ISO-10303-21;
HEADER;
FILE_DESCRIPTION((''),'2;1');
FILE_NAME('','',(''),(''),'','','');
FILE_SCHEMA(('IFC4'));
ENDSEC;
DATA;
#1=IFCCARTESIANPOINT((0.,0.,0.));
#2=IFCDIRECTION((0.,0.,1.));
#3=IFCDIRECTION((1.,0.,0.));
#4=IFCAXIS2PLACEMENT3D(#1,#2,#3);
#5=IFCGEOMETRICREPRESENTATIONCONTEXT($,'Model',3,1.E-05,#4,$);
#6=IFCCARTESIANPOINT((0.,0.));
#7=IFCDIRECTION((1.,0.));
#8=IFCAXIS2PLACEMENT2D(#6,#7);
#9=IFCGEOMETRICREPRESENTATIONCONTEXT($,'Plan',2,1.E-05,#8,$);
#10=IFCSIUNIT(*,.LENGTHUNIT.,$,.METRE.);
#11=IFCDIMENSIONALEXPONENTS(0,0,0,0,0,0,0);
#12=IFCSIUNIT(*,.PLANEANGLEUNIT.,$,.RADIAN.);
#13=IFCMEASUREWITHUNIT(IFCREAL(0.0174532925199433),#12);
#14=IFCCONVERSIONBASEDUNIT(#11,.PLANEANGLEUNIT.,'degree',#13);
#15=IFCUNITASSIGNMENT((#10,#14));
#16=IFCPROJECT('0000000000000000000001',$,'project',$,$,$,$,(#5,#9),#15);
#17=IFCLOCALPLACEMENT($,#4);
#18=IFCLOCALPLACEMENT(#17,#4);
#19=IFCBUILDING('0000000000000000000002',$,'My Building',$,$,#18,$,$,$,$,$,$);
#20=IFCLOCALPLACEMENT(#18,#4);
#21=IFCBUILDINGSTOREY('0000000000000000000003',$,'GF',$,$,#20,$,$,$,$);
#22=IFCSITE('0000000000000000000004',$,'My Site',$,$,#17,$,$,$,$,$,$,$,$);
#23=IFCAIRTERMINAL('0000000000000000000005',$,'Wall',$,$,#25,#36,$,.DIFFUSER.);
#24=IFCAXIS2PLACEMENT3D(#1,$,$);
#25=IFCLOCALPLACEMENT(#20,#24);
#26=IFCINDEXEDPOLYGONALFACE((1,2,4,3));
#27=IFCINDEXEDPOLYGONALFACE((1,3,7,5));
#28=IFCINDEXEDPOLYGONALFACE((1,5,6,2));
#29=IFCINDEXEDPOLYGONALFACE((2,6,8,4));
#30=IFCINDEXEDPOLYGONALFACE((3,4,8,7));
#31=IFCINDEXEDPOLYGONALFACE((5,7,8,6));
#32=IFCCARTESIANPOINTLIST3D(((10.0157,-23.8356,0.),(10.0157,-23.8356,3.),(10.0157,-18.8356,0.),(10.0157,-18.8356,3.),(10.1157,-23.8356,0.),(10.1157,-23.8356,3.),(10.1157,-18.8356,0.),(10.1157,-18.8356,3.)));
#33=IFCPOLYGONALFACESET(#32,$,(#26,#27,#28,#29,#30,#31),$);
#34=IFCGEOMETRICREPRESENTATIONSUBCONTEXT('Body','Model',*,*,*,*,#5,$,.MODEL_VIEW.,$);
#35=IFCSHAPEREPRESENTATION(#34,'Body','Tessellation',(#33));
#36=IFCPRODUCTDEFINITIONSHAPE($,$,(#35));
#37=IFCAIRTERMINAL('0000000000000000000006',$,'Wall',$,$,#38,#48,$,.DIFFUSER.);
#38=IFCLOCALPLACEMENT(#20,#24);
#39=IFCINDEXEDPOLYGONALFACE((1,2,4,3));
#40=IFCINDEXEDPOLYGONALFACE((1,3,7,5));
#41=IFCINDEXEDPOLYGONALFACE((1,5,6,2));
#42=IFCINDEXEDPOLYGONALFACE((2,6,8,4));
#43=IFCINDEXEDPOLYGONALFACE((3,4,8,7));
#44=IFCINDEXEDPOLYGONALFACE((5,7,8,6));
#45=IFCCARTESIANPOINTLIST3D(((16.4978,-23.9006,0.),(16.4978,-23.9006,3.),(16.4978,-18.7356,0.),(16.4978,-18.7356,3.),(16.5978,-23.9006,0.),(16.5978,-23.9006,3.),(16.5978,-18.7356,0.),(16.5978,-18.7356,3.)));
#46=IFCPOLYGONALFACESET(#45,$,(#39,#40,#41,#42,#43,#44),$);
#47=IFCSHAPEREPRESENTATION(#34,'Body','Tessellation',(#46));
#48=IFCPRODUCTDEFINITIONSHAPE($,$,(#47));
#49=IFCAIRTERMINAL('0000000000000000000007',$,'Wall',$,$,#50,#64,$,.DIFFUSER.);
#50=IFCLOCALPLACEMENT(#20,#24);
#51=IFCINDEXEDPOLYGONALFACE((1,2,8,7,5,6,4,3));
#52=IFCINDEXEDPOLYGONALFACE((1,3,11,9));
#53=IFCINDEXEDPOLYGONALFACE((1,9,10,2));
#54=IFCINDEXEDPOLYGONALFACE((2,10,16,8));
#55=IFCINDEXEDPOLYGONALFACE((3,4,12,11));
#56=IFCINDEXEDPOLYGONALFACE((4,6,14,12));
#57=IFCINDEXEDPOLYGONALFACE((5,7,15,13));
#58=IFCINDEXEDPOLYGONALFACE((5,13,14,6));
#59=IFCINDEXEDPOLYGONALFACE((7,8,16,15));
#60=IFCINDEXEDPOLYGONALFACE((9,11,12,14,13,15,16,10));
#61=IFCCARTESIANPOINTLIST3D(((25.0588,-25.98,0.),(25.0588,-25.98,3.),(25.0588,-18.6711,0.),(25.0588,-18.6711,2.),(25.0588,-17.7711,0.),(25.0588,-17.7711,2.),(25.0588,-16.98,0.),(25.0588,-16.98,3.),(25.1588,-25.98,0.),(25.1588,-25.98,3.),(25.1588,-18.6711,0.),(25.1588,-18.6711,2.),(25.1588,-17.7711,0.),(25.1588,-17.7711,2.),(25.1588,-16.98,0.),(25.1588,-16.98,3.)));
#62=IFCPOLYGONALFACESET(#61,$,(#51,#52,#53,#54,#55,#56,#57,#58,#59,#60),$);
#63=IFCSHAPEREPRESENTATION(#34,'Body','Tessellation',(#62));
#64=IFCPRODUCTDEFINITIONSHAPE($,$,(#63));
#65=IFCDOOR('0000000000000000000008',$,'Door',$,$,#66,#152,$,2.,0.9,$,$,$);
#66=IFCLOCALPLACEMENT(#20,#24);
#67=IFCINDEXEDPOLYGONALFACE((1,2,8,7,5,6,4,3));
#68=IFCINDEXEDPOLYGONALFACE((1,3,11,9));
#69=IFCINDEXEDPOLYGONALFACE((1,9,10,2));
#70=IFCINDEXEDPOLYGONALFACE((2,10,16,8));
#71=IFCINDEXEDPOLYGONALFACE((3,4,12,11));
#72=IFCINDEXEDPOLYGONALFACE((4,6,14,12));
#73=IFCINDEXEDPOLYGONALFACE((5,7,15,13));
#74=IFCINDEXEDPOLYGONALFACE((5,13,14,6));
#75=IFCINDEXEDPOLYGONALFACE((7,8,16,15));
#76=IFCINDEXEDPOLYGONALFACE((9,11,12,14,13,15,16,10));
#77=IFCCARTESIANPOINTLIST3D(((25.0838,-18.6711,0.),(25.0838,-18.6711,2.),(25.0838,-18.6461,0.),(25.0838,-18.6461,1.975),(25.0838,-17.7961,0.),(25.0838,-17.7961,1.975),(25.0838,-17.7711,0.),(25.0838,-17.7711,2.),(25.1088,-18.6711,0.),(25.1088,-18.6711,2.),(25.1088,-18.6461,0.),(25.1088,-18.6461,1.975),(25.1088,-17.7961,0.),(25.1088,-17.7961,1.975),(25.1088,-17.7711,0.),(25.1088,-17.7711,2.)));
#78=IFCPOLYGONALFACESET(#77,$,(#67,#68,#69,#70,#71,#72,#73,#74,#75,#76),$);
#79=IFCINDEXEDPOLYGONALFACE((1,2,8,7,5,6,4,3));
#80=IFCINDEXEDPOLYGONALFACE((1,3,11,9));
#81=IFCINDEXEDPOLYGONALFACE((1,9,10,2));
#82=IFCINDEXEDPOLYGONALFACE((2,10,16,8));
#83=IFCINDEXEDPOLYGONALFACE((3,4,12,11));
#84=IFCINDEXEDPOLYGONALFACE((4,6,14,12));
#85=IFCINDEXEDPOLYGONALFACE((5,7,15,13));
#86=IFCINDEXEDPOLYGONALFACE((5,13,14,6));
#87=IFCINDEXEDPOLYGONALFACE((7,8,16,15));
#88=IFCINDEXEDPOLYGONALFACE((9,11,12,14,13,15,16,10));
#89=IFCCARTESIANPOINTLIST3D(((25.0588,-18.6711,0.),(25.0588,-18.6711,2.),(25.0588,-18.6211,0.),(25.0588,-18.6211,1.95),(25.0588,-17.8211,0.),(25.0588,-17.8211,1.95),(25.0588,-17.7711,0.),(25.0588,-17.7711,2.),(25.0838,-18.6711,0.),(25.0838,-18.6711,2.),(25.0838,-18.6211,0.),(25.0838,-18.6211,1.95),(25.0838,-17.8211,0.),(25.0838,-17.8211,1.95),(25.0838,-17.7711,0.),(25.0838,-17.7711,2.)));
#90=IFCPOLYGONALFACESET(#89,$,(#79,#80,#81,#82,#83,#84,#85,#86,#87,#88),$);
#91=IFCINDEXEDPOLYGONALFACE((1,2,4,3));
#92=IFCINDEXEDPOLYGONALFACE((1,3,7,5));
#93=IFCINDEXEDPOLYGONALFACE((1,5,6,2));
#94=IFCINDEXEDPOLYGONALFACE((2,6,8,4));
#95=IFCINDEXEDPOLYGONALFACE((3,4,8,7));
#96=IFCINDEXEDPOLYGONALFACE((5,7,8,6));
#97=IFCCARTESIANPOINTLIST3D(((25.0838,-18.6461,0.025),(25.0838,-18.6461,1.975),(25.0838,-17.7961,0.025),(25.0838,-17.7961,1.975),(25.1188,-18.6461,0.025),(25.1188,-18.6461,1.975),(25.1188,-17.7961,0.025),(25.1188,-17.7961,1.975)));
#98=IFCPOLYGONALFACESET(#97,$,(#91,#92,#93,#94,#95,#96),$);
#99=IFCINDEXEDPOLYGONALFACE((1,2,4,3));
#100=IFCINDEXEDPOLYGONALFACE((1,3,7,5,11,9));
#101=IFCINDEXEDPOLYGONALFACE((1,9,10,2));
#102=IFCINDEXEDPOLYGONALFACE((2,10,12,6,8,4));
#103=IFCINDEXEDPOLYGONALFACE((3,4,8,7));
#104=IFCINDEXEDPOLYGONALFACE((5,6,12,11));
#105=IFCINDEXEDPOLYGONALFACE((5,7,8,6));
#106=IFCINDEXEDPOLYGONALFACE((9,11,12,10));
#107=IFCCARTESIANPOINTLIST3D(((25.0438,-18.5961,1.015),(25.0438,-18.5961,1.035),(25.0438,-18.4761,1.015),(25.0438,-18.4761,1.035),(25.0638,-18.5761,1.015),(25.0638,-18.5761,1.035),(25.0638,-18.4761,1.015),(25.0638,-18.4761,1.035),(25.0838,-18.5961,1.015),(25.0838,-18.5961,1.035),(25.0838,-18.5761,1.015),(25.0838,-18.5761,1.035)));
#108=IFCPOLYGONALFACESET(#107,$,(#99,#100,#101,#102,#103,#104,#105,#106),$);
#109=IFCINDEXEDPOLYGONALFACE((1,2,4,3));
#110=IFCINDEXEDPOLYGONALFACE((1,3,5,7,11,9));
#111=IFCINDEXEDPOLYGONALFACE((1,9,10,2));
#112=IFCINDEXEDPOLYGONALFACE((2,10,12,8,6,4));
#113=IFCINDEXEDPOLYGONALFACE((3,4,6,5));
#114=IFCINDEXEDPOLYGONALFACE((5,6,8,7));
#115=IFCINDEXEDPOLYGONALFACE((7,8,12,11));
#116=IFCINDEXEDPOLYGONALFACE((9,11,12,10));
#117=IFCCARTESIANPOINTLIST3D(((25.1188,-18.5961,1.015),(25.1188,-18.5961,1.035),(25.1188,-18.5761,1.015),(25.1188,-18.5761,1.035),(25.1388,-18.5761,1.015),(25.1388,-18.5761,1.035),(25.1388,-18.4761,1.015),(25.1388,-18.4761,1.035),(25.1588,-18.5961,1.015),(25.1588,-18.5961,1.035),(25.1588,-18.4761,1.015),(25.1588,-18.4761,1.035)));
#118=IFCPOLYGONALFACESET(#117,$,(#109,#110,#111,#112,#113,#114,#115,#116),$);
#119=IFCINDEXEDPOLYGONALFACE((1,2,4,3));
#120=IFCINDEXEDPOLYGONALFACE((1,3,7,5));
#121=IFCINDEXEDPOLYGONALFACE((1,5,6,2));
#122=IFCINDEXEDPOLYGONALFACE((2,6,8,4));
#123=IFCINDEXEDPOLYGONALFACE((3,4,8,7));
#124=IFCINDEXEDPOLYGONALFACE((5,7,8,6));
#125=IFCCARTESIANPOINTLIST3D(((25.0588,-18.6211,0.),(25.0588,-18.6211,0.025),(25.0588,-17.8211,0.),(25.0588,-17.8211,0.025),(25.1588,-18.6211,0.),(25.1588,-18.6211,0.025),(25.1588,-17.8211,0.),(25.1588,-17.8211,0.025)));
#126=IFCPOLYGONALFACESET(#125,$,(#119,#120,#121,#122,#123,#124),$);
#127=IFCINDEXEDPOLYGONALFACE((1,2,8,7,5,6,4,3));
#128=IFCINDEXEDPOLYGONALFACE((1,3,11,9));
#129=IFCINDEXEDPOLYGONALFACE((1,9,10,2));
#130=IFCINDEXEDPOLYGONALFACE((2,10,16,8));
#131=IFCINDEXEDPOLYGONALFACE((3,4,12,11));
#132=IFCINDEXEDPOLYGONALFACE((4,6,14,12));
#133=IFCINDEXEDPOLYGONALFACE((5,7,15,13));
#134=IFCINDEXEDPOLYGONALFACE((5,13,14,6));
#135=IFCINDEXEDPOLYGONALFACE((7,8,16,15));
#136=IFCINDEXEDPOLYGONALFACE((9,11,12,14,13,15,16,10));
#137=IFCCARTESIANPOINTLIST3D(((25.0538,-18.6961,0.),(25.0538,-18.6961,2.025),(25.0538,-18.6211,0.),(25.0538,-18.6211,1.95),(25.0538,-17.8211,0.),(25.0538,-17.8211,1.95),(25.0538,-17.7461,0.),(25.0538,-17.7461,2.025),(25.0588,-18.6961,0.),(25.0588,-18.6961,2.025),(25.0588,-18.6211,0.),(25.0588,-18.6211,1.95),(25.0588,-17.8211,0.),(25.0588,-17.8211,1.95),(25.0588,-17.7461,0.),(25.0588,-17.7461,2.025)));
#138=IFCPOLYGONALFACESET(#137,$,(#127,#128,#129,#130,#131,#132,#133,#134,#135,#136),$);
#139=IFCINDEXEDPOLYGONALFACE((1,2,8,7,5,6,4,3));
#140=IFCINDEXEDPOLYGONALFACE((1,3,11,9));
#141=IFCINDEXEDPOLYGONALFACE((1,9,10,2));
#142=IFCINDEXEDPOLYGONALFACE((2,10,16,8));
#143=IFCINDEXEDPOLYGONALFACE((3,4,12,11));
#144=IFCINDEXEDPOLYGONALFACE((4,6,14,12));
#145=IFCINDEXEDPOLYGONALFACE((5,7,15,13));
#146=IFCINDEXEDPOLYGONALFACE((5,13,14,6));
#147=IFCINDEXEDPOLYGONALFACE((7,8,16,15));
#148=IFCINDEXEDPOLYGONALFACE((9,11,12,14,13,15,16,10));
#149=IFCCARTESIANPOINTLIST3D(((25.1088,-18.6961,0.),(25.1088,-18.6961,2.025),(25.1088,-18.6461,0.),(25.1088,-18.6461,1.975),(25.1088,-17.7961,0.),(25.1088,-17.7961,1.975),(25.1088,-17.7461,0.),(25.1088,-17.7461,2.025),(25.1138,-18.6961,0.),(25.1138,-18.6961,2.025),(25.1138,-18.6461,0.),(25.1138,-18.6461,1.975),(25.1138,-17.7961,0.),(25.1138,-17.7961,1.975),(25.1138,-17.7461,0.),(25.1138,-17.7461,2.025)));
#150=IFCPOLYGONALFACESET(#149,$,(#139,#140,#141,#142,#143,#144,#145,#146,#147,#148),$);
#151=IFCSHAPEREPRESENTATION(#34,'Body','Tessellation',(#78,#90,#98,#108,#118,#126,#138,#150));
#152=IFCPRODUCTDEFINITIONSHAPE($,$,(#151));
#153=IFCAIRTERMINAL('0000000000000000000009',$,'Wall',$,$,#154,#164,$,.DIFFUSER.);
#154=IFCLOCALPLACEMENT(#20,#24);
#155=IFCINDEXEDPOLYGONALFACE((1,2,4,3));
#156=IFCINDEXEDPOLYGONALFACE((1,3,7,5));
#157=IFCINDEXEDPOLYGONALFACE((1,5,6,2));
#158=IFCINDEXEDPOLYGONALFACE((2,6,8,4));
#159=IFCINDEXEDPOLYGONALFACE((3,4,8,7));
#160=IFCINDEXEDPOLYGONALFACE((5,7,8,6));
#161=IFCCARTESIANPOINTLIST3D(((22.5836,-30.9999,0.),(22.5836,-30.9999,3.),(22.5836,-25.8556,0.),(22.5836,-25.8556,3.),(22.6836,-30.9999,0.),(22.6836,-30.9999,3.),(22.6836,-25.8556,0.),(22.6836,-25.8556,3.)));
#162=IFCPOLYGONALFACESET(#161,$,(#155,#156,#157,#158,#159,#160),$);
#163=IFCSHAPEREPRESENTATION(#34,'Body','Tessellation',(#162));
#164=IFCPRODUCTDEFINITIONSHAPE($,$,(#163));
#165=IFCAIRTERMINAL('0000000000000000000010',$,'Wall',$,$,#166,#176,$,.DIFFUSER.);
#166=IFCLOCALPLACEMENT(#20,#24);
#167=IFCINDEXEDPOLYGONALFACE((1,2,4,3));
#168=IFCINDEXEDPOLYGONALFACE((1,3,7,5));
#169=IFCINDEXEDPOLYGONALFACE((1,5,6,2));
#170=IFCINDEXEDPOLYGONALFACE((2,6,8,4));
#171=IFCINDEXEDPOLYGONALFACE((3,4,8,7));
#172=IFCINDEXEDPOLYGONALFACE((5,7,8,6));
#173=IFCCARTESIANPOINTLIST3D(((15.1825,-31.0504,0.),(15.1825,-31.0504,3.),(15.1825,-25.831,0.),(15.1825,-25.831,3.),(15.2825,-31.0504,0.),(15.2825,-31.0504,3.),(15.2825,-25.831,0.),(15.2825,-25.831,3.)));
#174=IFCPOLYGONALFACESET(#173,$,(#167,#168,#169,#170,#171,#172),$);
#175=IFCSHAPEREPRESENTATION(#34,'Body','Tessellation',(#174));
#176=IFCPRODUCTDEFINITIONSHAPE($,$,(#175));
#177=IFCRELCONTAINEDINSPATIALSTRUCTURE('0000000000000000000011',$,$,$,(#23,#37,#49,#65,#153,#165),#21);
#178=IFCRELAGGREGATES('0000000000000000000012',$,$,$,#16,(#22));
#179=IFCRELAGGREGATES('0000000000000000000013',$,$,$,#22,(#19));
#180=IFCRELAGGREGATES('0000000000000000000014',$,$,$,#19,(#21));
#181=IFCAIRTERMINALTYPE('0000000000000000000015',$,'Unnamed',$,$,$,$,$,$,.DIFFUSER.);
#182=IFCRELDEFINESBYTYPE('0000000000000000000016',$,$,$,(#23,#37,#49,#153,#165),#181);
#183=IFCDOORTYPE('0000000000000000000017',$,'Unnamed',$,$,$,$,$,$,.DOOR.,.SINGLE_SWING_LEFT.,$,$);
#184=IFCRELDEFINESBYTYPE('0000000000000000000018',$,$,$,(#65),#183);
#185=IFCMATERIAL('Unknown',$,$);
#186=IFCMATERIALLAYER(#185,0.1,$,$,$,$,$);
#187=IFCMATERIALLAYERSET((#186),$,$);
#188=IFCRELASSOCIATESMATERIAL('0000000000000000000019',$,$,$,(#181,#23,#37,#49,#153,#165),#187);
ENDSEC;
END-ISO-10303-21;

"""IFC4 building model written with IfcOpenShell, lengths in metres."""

from ifc_helpers import new_model, entity, si_unit, converted_unit, frame, origin_with_axes, origin_2d_with_axis, place, context, subcontext, project, spatial, line, indexed_curve, outline, extrude, shape, source, transform, mapped, material, layer, layer_set, layer_usage, type_object, type_shapes, element, fill, save


model = new_model("IFC4")

# Units and contexts
model_context = context("Model", 3, precision=1e-05, world=origin_with_axes())
plan_context = context("Plan", 2, precision=1e-05, world=origin_2d_with_axis())
body_context_1 = subcontext(model_context, "Body", "Model", "MODEL_VIEW")
body_context_2 = subcontext(plan_context, "Body", "Plan", "PLAN_VIEW")
ifc_project = project(units=[si_unit("LENGTHUNIT", "METRE"), converted_unit("PLANEANGLEUNIT", "degree", entity("IfcReal", 0.0174532925199433), si_unit("PLANEANGLEUNIT", "RADIAN"), dimensions=[0, 0, 0, 0, 0, 0, 0])], contexts=[model_context, plan_context])

# Site, building, storey
site_placement = place(None, origin_with_axes())
site = spatial("IfcSite", under=ifc_project, at=site_placement, Name="My Site")
building_placement = place(site_placement, origin_with_axes())
building = spatial("IfcBuilding", under=site, at=building_placement, Name="My Building")
storey_placement = place(building_placement, origin_with_axes())
storey = spatial("IfcBuildingStorey", under=building, at=storey_placement, Name="GF")

# Shared definitions
ifc_material = material(Name="Unknown")
ifc_layer = layer(ifc_material, 0.1)
ifc_layer_set = layer_set([ifc_layer])
air_terminal_type = type_object("IfcAirTerminalType", Name="Unnamed", PredefinedType="DIFFUSER", material=ifc_layer_set)

# Shared definitions
shared_shape_1 = source(origin_with_axes(), body_context_1, "Body", "SweptSolid", [
    extrude(outline(indexed_curve([(0.0, 0.0), (0.9, 0.0), (0.9, 2.0), (0.0, 2.0)], segments=[line(1, 2, 3, 4, 1)])), frame((0.0, -0.6, 0.0), z_axis=(0.0, -1.0, 0.0), x_axis=(1.0, 0.0, 0.0)), (0.0, 0.0, -1.0), 1.2),
])
door_type = type_object("IfcDoorType", Name="Unnamed", OperationType="SINGLE_SWING_LEFT", PredefinedType="DOOR")
shared_shape_2 = source(origin_with_axes(), body_context_1, "Body", "SweptSolid", [
    extrude(outline(indexed_curve([(0.0, 0.0), (0.0, 2.0), (0.9, 2.0), (0.9, 0.0), (0.875, 0.0), (0.875, 1.975), (0.025, 1.975), (0.025, 0.0)], segments=[line(1, 2, 3, 4, 5, 6, 7, 8, 1)])), frame((0.0, 0.025, 0.0), z_axis=(0.0, -1.0, 0.0), x_axis=(1.0, 0.0, 0.0)), (0.0, 0.0, -1.0), 0.025),
    extrude(outline(indexed_curve([(0.0, 0.0), (0.0, 2.0), (0.9, 2.0), (0.9, 0.0), (0.85, 0.0), (0.85, 1.95), (0.05, 1.95), (0.05, 0.0)], segments=[line(1, 2, 3, 4, 5, 6, 7, 8, 1)])), frame((0.0, 0.0, 0.0), z_axis=(0.0, -1.0, 0.0), x_axis=(1.0, 0.0, 0.0)), (0.0, 0.0, -1.0), 0.025),
    extrude(outline(indexed_curve([(0.0, 0.0), (0.85, 0.0), (0.85, 0.035), (0.0, 0.035)], segments=[line(1, 2, 3, 4, 1)])), frame((0.025, 0.025, 0.025), z_axis=(0.0, 0.0, 1.0), x_axis=(1.0, 0.0, 0.0)), (0.0, 0.0, 1.0), 1.95),
    extrude(outline(indexed_curve([(0.0, 0.0), (0.0, -0.04), (-0.12, -0.04), (-0.12, -0.02), (-0.02, -0.02), (-0.02, 0.0)], segments=[line(1, 2, 3, 4, 5, 6, 1)])), frame((0.825, 0.025, 1.015), z_axis=(0.0, 0.0, 1.0), x_axis=(1.0, 0.0, 0.0)), (0.0, 0.0, 1.0), 0.02),
    extrude(outline(indexed_curve([(0.0, 0.0), (0.0, 0.04), (-0.12, 0.04), (-0.12, 0.02), (-0.02, 0.02), (-0.02, 0.0)], segments=[line(1, 2, 3, 4, 5, 6, 1)])), frame((0.825, 0.06, 1.015), z_axis=(0.0, 0.0, 1.0), x_axis=(1.0, 0.0, 0.0)), (0.0, 0.0, 1.0), 0.02),
    extrude(outline(indexed_curve([(0.0, 0.0), (0.8, 0.0), (0.8, 0.1), (0.0, 0.1)], segments=[line(1, 2, 3, 4, 1)])), frame((0.05, 0.0, 0.0), z_axis=(0.0, 0.0, 1.0), x_axis=(1.0, 0.0, 0.0)), (0.0, 0.0, 1.0), 0.025),
    extrude(outline(indexed_curve([(0.0, 0.0), (0.0, 2.025), (0.95, 2.025), (0.95, 0.0), (0.875, 0.0), (0.875, 1.95), (0.075, 1.95), (0.075, 0.0)], segments=[line(1, 2, 3, 4, 5, 6, 7, 8, 1)])), frame((-0.025, -0.005, 0.0), z_axis=(0.0, -1.0, 0.0), x_axis=(1.0, 0.0, 0.0)), (0.0, 0.0, -1.0), 0.005),
    extrude(outline(indexed_curve([(0.0, 0.0), (0.0, 2.025), (0.95, 2.025), (0.95, 0.0), (0.9, 0.0), (0.9, 1.975), (0.05, 1.975), (0.05, 0.0)], segments=[line(1, 2, 3, 4, 5, 6, 7, 8, 1)])), frame((-0.025, 0.05, 0.0), z_axis=(0.0, -1.0, 0.0), x_axis=(1.0, 0.0, 0.0)), (0.0, 0.0, -1.0), 0.005),
])
shared_shape_3 = source(origin_with_axes(), body_context_2, "Body", "Curve2D", [
    entity("IfcIndexedPolyCurve", entity("IfcCartesianPointList2D", [[0.0, 0.0], [0.0, 0.05], [0.025, 0.05], [0.025, 0.025], [0.05, 0.025], [0.05, 0.0]]), [entity("IfcLineIndex", [1, 2, 3, 4, 5, 6, 1])]),
    entity("IfcIndexedPolyCurve", entity("IfcCartesianPointList2D", [[0.9, 0.0], [0.9, 0.05], [0.875, 0.05], [0.875, 0.025], [0.85, 0.025], [0.85, 0.0]]), [entity("IfcLineIndex", [1, 2, 3, 4, 5, 6, 1])]),
    entity("IfcTrimmedCurve", entity("IfcEllipse", entity("IfcAxis2Placement2D", entity("IfcCartesianPoint", [0.06, 0.05]), entity("IfcDirection", [1.0, 0.0])), 0.815, 0.85), [entity("IfcCartesianPoint", [0.875, 0.05])], [entity("IfcCartesianPoint", [0.06, 0.9])], True, "CARTESIAN"),
    entity("IfcIndexedPolyCurve", entity("IfcCartesianPointList2D", [[0.025, 0.05], [0.06, 0.05], [0.06, 0.9], [0.025, 0.9]]), [entity("IfcLineIndex", [1, 2, 3, 4, 1])]),
])
type_shapes(door_type, [shared_shape_2, shared_shape_3])

# Air terminals
ifc_layer_usage_1 = layer_usage(ifc_layer_set, "AXIS2", "POSITIVE", 0.0)
air_terminal_1_placement = place(storey_placement, frame((10.0157, -18.8356, 0.0), z_axis=(0.0, 0.0, 1.0), x_axis=(0.0, -1.0, 0.0)))
element("IfcAirTerminal", 1, at=air_terminal_1_placement, inside=storey, type_object=air_terminal_type, material=ifc_layer_usage_1, Name="Wall", PredefinedType="DIFFUSER", context=body_context_1, shape_type="SweptSolid", body=[
    extrude(outline(indexed_curve([(0.0, 0.0), (0.0, 0.1), (5.0, 0.1), (5.0, 0.0)], segments=[line(1, 2, 3, 4, 1)])), origin_with_axes(), (0.0, 0.0, 1.0), 3.0),
])
ifc_layer_usage_2 = layer_usage(ifc_layer_set, "AXIS2", "POSITIVE", 0.0)
air_terminal_2_placement = place(storey_placement, frame((16.4978, -18.7356, 0.0), z_axis=(0.0, 0.0, 1.0), x_axis=(0.0, -1.0, 0.0)))
element("IfcAirTerminal", 2, at=air_terminal_2_placement, inside=storey, type_object=air_terminal_type, material=ifc_layer_usage_2, Name="Wall", PredefinedType="DIFFUSER", context=body_context_1, shape_type="SweptSolid", body=[
    extrude(outline(indexed_curve([(0.0, 0.0), (0.0, 0.1), (5.1651, 0.1), (5.1651, 0.0)], segments=[line(1, 2, 3, 4, 1)])), origin_with_axes(), (0.0, 0.0, 1.0), 3.0),
])

# Air terminal, opening, door
ifc_layer_usage_3 = layer_usage(ifc_layer_set, "AXIS2", "POSITIVE", 0.0)
air_terminal_3_placement = place(storey_placement, frame((25.0588, -16.98, 0.0), z_axis=(0.0, 0.0, 1.0), x_axis=(0.0, -1.0, 0.0)))
air_terminal_3 = element("IfcAirTerminal", 3, at=air_terminal_3_placement, inside=storey, type_object=air_terminal_type, material=ifc_layer_usage_3, Name="Wall", PredefinedType="DIFFUSER", context=body_context_1, shape_type="SweptSolid", body=[
    extrude(outline(indexed_curve([(0.0, 0.0), (0.0, 0.1), (9.0, 0.1), (9.0, 0.0)], segments=[line(1, 2, 3, 4, 1)])), origin_with_axes(), (0.0, 0.0, 1.0), 3.0),
])
opening_1_placement = place(air_terminal_3_placement, frame((0.7911, 0.0, 0.0), z_axis=(0.0, 0.0, 1.0), x_axis=(1.0, 0.0, 0.0)))
opening_1 = element("IfcOpeningElement", 4, at=opening_1_placement, cuts=air_terminal_3, PredefinedType="OPENING", context=body_context_1, shape_type="MappedRepresentation", body=[
    mapped(shared_shape_1, transform((0.0, 0.0, 0.0), x_axis=(1.0, 0.0, 0.0), y_axis=(0.0, 1.0, 0.0), z_axis=(0.0, 0.0, 1.0), scale=1.0)),
])
door_1_placement = place(opening_1_placement, frame((0.0, 0.0, 0.0), z_axis=(0.0, 0.0, 1.0), x_axis=(1.0, 0.0, 0.0)))
door_1 = element("IfcDoor", 5, at=door_1_placement, inside=storey, type_object=door_type, Name="Door", OverallHeight=2.0, OverallWidth=0.9, shapes=[
    shape(body_context_1, "Body", "MappedRepresentation", [mapped(shared_shape_2, transform((0.0, 0.0, 0.0), x_axis=(1.0, 0.0, 0.0), y_axis=(0.0, 1.0, 0.0), z_axis=(0.0, 0.0, 1.0), scale=1.0))]),
    shape(body_context_2, "Body", "MappedRepresentation", [mapped(shared_shape_3, transform((0.0, 0.0, 0.0), x_axis=(1.0, 0.0, 0.0), y_axis=(0.0, 1.0, 0.0), z_axis=(0.0, 0.0, 1.0), scale=1.0))]),
])
fill(opening_1, door_1)

# Air terminals
ifc_layer_usage_4 = layer_usage(ifc_layer_set, "AXIS2", "POSITIVE", 0.0)
air_terminal_4_placement = place(storey_placement, frame((22.5836, -25.8556, 0.0), z_axis=(0.0, 0.0, 1.0), x_axis=(0.0, -1.0, 0.0)))
element("IfcAirTerminal", 6, at=air_terminal_4_placement, inside=storey, type_object=air_terminal_type, material=ifc_layer_usage_4, Name="Wall", PredefinedType="DIFFUSER", context=body_context_1, shape_type="SweptSolid", body=[
    extrude(outline(indexed_curve([(0.0, 0.0), (0.0, 0.1), (5.1443, 0.1), (5.1443, 0.0)], segments=[line(1, 2, 3, 4, 1)])), origin_with_axes(), (0.0, 0.0, 1.0), 3.0),
])
ifc_layer_usage_5 = layer_usage(ifc_layer_set, "AXIS2", "POSITIVE", 0.0)
air_terminal_5_placement = place(storey_placement, frame((15.1825, -25.831, 0.0), z_axis=(0.0, 0.0, 1.0), x_axis=(0.0, -1.0, 0.0)))
element("IfcAirTerminal", 7, at=air_terminal_5_placement, inside=storey, type_object=air_terminal_type, material=ifc_layer_usage_5, Name="Wall", PredefinedType="DIFFUSER", context=body_context_1, shape_type="SweptSolid", body=[
    extrude(outline(indexed_curve([(0.0, 0.0), (0.0, 0.1), (5.2194, 0.1), (5.2194, 0.0)], segments=[line(1, 2, 3, 4, 1)])), origin_with_axes(), (0.0, 0.0, 1.0), 3.0),
])

save(model, "model.ifc")
